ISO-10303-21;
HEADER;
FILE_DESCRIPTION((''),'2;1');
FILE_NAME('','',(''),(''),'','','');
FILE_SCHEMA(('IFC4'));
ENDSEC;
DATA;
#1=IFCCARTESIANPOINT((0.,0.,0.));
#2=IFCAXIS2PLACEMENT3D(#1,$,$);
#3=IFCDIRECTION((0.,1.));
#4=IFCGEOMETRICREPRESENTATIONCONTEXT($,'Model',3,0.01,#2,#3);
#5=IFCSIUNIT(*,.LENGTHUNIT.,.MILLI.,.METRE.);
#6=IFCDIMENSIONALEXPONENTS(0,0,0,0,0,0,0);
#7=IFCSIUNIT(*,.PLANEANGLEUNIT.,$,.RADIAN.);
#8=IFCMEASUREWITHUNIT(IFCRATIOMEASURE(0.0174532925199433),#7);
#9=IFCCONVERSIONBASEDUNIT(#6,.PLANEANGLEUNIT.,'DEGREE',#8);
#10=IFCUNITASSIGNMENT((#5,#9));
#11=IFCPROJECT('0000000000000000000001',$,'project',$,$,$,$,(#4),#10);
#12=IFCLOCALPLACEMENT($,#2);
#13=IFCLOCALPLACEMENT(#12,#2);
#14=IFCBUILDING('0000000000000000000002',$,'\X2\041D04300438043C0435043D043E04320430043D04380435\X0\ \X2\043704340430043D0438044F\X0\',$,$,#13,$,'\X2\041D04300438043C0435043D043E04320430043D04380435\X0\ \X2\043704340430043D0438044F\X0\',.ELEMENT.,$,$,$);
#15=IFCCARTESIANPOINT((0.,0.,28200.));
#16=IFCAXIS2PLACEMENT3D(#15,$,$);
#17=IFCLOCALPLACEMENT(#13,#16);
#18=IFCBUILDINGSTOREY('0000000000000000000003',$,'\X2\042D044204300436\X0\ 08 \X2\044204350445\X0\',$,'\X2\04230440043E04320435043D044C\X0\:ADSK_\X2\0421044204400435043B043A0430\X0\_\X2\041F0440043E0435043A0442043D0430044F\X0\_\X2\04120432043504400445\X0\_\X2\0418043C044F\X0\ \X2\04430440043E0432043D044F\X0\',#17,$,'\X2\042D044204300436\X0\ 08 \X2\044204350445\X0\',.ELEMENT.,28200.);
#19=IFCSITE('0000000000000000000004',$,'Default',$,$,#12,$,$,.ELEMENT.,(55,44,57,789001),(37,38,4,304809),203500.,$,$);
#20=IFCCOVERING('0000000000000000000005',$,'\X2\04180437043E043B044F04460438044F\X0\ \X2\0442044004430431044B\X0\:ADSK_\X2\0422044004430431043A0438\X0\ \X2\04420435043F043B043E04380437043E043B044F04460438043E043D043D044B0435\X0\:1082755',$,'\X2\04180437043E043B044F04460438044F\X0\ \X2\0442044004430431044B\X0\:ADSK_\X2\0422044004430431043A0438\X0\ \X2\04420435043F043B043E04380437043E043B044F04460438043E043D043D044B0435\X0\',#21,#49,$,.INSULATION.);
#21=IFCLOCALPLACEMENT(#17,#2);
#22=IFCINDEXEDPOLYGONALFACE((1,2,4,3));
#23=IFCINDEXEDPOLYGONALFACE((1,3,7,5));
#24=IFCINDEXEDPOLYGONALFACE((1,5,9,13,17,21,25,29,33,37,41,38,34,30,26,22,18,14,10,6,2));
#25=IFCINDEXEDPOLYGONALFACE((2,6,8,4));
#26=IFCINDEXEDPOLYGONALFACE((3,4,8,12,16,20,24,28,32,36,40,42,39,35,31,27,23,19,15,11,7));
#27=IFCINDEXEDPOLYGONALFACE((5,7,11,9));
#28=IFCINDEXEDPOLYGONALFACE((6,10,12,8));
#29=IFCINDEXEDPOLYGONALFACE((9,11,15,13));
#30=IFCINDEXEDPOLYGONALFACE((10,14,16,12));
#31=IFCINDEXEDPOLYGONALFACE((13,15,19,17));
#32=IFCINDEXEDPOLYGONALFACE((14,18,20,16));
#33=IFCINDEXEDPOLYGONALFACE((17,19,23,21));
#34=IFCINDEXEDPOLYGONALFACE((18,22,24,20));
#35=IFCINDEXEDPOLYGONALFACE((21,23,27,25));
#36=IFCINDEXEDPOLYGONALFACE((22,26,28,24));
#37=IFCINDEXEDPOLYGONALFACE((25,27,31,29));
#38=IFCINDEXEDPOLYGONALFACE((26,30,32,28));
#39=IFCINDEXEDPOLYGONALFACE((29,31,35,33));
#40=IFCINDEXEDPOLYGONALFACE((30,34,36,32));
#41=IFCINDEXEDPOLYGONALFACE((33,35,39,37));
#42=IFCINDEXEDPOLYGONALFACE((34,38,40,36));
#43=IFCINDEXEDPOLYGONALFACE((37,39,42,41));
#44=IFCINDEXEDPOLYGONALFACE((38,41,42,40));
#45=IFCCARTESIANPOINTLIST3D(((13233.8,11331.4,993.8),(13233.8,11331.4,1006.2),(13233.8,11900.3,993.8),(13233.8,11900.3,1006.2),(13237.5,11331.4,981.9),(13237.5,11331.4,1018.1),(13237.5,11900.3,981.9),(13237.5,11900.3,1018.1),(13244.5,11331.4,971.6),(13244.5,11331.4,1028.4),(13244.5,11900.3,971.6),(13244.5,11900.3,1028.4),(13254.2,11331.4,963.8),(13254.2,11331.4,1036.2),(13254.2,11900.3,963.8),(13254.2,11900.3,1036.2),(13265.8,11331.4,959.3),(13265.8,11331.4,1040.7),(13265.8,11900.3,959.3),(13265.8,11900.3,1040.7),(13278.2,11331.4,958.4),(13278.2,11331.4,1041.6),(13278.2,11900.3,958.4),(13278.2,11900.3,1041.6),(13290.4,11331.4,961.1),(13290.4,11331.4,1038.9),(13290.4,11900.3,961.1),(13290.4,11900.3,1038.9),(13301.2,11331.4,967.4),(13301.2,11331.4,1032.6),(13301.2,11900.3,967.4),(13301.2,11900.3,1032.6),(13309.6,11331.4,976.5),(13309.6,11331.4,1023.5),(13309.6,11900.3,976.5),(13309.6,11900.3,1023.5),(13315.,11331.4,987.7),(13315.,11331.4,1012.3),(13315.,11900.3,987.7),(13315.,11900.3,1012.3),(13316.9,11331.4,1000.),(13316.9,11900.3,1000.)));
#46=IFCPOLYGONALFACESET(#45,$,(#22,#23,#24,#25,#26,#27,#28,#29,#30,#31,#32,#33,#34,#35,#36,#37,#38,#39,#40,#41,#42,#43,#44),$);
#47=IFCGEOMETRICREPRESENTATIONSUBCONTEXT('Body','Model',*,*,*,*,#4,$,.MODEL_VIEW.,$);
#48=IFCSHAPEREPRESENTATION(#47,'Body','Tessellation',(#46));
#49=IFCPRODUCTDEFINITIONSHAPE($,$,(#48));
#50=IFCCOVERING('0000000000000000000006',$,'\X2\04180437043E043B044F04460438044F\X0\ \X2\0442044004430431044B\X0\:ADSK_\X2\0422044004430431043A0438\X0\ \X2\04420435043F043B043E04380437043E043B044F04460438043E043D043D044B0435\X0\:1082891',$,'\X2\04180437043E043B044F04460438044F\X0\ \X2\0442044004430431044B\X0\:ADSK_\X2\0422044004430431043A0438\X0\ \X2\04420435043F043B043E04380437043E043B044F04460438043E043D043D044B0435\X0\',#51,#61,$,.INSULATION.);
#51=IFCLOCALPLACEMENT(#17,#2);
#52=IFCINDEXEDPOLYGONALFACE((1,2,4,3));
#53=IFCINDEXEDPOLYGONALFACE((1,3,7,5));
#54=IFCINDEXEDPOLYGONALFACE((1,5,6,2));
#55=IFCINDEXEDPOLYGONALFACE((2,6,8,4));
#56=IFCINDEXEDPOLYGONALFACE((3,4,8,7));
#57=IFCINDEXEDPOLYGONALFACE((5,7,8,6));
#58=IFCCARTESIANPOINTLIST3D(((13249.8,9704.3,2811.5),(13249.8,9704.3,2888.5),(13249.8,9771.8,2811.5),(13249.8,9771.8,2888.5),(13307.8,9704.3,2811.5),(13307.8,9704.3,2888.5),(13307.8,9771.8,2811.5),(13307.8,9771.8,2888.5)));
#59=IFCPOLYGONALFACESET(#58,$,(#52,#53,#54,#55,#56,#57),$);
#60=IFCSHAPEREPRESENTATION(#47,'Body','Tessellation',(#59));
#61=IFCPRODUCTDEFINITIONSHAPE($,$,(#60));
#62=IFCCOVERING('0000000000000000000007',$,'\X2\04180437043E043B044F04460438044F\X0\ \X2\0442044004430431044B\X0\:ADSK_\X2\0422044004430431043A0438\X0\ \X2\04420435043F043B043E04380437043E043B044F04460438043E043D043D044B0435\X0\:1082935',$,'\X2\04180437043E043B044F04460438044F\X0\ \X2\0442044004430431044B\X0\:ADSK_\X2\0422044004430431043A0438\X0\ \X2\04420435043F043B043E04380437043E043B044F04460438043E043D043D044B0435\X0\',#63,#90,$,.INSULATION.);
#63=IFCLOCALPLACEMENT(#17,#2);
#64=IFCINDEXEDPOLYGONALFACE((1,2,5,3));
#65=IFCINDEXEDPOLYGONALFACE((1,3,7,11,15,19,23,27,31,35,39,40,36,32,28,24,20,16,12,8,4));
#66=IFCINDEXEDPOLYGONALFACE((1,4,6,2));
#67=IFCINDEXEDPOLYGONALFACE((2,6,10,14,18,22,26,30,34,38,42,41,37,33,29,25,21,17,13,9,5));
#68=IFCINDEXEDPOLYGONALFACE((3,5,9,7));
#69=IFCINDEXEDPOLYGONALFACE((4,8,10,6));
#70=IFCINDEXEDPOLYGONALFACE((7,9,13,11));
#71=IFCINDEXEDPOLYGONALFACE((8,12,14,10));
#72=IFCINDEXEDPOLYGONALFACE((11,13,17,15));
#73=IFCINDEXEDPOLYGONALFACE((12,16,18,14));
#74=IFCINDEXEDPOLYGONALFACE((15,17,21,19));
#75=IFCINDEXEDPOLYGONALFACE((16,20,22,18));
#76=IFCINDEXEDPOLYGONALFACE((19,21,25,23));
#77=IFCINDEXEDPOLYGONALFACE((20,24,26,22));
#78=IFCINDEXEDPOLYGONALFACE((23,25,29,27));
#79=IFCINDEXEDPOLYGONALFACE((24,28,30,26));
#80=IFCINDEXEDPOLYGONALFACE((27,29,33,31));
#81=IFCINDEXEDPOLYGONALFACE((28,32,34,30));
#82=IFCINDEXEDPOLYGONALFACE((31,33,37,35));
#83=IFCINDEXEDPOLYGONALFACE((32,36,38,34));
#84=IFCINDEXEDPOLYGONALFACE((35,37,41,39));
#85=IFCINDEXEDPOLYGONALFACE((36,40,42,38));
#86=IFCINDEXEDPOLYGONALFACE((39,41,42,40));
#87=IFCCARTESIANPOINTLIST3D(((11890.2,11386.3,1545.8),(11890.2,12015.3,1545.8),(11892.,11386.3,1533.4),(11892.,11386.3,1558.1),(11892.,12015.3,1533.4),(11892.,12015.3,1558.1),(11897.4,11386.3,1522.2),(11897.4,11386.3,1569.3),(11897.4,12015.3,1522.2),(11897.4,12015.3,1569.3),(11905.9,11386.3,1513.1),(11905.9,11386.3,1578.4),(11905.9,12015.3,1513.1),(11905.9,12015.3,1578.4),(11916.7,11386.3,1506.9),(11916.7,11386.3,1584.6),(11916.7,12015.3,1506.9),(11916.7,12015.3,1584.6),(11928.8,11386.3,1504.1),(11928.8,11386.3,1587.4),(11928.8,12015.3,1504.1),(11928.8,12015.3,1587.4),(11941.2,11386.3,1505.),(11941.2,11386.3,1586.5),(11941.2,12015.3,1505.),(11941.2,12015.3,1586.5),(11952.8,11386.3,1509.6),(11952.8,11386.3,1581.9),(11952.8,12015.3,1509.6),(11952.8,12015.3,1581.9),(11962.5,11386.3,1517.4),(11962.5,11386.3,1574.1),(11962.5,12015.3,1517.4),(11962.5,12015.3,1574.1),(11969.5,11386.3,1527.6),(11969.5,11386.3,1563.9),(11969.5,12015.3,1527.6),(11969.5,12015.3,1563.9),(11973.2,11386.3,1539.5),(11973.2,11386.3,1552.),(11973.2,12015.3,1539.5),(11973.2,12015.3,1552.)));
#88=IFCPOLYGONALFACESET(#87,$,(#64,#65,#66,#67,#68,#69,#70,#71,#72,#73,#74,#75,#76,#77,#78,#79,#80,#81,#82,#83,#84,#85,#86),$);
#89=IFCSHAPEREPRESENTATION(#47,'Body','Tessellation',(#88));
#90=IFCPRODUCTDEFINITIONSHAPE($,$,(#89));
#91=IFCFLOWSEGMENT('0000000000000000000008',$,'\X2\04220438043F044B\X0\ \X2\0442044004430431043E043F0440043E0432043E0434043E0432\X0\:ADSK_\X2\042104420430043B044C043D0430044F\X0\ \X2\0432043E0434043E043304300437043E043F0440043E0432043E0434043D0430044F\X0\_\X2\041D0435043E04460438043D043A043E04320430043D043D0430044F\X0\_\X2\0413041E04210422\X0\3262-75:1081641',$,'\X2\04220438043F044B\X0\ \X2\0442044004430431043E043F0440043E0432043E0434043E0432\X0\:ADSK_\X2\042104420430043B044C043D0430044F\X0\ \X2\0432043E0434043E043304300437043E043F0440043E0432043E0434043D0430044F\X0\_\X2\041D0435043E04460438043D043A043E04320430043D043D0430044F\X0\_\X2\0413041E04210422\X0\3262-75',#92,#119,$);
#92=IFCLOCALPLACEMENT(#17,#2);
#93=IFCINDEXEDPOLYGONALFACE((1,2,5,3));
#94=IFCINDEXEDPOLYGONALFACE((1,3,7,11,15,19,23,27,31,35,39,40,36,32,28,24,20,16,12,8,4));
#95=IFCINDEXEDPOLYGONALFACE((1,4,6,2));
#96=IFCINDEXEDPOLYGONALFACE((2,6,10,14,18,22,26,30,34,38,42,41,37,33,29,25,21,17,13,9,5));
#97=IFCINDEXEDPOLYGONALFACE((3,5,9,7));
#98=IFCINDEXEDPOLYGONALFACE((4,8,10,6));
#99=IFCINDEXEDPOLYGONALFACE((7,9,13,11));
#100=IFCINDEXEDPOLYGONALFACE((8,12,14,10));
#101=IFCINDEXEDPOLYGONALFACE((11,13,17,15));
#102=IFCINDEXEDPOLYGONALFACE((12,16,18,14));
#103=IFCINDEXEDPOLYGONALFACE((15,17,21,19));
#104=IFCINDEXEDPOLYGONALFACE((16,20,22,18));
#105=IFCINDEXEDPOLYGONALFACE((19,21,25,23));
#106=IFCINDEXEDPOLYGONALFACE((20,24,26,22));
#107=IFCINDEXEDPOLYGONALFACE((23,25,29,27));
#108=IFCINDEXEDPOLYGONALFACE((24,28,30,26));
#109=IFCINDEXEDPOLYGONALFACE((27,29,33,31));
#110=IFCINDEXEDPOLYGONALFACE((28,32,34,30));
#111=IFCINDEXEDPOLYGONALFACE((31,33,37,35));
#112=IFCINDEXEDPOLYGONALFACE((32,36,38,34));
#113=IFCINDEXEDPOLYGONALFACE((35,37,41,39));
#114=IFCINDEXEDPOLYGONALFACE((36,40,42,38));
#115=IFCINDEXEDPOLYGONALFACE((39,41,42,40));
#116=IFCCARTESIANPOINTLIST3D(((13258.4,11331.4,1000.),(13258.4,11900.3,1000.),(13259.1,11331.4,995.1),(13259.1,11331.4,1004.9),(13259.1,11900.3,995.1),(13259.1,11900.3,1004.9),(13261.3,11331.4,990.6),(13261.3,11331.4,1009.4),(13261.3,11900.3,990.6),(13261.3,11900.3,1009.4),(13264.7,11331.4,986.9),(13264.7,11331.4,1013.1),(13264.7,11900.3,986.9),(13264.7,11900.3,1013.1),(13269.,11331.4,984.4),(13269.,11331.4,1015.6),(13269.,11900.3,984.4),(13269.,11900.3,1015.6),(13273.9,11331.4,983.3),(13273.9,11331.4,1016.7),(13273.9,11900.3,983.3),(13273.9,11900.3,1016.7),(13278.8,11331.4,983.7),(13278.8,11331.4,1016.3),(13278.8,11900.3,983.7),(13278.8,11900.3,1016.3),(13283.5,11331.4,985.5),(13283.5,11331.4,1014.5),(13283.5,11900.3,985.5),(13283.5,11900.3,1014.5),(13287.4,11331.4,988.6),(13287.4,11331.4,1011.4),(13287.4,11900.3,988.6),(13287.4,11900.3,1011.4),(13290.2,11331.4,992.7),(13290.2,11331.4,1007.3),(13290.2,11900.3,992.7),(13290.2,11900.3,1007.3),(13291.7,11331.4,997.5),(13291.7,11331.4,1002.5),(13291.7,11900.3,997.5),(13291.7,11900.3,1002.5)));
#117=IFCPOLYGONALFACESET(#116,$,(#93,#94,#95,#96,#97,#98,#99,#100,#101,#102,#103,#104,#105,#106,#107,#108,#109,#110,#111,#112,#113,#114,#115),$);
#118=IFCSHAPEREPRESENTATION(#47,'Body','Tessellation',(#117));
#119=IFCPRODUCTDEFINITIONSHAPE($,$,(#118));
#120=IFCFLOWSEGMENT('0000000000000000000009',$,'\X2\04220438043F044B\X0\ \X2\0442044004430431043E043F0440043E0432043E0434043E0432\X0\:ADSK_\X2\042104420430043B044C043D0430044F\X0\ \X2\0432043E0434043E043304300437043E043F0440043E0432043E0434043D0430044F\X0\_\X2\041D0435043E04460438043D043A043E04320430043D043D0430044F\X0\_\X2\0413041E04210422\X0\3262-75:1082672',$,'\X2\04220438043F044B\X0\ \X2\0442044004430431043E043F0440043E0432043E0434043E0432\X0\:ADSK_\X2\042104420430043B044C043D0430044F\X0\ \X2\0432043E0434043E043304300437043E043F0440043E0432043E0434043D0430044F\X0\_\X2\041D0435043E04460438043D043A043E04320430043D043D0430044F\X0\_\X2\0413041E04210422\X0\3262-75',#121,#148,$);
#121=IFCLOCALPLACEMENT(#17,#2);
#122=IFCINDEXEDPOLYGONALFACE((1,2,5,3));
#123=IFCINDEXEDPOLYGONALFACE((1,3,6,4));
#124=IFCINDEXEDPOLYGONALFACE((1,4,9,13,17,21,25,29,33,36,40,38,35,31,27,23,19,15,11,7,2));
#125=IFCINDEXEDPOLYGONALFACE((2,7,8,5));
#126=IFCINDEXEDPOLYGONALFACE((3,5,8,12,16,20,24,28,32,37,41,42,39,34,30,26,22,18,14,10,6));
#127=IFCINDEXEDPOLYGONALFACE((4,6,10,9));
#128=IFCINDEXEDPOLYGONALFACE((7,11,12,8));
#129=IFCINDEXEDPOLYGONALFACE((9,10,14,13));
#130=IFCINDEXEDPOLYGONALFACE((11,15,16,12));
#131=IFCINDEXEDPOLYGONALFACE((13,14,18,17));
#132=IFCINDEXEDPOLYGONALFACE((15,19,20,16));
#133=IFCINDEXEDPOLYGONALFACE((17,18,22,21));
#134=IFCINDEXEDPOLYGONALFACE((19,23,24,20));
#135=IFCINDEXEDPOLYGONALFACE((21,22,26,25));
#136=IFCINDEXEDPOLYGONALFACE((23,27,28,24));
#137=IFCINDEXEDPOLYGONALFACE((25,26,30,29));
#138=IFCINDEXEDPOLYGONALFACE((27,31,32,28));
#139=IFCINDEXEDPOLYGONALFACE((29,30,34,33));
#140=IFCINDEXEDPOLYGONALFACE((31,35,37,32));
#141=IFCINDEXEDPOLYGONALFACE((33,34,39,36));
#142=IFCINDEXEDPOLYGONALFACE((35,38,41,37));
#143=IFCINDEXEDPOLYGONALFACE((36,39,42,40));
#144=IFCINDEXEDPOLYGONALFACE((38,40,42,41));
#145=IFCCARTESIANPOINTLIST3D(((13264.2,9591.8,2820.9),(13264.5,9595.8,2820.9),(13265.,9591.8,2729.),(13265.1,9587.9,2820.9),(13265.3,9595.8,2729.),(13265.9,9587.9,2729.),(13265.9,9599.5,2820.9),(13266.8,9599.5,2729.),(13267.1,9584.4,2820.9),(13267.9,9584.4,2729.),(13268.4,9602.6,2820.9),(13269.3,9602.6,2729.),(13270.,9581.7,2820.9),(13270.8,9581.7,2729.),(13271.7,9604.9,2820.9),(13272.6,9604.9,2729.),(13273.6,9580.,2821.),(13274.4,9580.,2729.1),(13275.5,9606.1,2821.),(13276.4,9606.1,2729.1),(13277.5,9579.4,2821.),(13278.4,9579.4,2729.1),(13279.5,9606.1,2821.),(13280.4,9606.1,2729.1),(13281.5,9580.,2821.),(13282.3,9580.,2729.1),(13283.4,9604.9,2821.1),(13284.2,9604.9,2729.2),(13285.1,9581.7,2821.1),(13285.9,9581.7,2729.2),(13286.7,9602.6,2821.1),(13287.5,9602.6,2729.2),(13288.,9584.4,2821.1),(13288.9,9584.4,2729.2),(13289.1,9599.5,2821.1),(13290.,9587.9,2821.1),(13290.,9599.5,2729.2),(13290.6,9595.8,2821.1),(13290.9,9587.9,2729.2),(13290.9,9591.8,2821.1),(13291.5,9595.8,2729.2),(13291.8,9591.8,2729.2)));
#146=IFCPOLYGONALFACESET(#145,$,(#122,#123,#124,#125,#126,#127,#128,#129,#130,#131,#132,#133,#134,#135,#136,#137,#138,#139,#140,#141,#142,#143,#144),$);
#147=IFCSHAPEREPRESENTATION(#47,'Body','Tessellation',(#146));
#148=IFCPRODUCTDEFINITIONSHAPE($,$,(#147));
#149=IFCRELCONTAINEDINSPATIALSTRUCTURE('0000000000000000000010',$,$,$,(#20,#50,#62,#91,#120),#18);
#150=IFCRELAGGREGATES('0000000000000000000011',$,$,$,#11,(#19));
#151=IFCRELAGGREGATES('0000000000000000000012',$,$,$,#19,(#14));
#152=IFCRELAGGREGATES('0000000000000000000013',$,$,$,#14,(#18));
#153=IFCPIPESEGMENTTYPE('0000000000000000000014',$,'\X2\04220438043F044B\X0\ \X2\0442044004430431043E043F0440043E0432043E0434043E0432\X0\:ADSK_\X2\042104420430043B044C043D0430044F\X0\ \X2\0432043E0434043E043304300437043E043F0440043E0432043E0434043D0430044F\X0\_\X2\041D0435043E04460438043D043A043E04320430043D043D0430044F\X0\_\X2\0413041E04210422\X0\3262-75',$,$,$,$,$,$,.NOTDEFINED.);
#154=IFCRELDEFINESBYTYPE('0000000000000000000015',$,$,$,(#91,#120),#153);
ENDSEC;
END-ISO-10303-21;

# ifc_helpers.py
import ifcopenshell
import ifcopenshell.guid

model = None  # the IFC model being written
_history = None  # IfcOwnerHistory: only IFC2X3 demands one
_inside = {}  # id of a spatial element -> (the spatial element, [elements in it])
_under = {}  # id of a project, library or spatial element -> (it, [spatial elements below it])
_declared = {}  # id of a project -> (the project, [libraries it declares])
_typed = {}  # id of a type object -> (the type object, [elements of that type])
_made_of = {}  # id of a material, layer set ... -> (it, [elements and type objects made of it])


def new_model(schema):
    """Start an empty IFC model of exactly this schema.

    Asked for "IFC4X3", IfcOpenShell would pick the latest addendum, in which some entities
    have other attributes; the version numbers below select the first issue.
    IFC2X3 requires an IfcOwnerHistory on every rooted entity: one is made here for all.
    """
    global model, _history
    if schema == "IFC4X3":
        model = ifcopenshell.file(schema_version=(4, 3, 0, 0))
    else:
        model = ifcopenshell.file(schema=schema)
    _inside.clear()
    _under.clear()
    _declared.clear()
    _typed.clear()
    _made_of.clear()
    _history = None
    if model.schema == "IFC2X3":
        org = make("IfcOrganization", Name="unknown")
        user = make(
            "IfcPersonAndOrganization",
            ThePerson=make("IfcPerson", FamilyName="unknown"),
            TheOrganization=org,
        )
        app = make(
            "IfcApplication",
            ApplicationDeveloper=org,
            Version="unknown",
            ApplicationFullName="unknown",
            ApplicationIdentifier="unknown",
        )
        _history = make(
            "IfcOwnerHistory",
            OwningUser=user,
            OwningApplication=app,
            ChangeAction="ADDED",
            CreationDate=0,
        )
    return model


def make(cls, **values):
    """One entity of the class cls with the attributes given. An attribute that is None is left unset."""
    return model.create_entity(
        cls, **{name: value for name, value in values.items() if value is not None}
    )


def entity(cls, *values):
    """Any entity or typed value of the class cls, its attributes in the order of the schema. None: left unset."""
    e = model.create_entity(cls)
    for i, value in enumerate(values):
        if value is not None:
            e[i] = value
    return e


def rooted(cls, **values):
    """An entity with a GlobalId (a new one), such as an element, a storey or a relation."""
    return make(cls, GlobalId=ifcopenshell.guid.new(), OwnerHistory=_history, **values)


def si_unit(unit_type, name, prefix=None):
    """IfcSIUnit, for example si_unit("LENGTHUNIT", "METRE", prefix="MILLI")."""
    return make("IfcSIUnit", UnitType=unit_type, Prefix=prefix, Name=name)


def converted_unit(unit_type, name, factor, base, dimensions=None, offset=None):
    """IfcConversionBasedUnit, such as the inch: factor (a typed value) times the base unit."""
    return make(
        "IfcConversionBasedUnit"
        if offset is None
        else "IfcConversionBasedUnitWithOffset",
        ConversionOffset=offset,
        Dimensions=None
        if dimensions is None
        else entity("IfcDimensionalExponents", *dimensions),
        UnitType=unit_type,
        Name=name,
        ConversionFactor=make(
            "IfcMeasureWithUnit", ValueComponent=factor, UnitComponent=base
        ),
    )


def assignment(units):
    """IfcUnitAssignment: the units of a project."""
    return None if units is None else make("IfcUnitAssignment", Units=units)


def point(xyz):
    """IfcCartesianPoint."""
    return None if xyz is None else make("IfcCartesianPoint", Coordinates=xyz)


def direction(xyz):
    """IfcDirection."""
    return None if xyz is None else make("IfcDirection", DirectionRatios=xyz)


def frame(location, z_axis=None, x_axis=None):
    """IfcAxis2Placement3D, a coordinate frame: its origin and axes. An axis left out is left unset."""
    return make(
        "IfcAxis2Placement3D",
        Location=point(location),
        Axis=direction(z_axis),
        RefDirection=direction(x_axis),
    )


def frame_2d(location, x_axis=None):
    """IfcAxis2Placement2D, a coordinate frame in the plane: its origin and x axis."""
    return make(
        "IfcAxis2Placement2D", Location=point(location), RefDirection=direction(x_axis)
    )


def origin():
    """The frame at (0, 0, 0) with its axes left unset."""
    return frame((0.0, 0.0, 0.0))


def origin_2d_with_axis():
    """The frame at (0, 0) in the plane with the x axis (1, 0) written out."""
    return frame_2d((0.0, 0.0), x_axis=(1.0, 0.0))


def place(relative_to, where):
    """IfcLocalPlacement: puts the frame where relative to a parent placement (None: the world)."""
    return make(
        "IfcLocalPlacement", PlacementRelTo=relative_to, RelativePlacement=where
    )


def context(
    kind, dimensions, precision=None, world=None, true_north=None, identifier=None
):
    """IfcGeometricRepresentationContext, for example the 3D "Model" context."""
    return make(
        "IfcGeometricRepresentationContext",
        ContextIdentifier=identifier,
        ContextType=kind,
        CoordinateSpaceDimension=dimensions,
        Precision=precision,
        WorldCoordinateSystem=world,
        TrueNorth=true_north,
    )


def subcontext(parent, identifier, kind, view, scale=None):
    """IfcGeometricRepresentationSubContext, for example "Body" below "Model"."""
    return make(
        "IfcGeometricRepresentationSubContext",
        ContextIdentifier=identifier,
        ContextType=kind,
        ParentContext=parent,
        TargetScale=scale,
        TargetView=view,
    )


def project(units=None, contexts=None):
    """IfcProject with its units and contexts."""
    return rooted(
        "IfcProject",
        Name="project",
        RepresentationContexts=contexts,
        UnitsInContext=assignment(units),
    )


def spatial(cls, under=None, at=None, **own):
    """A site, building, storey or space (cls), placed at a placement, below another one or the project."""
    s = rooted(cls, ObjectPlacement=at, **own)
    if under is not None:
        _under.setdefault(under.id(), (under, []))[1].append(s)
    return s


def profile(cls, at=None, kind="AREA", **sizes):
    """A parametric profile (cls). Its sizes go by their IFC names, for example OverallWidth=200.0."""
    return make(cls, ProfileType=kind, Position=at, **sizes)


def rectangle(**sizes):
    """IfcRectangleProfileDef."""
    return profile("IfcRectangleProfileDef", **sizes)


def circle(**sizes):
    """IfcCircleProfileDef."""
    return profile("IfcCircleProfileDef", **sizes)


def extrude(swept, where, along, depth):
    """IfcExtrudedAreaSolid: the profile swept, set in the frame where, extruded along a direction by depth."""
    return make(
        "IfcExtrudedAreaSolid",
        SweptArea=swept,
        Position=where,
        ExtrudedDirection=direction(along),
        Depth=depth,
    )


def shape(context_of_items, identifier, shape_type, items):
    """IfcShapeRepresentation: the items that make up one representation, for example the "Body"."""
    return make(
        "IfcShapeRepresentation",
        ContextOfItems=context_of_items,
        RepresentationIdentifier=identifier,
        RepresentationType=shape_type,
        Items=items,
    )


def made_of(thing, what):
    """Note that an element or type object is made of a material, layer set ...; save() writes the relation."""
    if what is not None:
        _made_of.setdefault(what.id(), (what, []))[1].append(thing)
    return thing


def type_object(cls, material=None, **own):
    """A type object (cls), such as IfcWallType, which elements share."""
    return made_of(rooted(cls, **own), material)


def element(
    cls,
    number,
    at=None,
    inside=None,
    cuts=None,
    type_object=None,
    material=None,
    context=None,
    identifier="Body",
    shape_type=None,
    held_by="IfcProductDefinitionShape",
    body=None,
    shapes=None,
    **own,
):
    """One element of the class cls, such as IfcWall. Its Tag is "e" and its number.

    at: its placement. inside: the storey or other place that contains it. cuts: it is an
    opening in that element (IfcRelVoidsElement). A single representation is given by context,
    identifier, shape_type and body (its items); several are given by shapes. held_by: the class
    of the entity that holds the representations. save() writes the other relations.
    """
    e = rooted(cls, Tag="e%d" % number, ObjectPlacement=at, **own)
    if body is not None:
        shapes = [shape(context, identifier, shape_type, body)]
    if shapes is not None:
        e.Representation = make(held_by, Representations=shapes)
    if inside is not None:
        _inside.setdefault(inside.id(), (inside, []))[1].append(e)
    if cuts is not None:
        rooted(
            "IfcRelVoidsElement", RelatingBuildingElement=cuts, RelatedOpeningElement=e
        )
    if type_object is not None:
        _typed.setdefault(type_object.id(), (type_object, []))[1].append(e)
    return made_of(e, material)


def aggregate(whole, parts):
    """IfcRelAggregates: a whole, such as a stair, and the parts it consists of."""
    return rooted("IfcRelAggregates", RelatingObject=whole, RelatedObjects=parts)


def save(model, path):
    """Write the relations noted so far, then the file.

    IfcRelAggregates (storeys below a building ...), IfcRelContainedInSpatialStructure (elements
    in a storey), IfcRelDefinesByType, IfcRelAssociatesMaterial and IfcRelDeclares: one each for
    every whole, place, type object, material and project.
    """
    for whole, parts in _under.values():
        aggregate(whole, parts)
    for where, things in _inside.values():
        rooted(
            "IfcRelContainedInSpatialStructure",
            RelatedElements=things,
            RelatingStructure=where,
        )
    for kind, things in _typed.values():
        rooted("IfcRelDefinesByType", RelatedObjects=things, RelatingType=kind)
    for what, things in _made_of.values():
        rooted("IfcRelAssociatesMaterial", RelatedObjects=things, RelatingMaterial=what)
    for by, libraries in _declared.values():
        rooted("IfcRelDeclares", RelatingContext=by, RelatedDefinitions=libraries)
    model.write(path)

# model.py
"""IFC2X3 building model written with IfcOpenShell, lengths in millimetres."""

from ifc_helpers import new_model, entity, si_unit, converted_unit, direction, frame, origin, origin_2d_with_axis, place, context, subcontext, project, spatial, rectangle, circle, extrude, type_object, element, save


model = new_model("IFC2X3")

# Units and contexts
model_context = context("Model", 3, precision=0.01, world=origin(), true_north=direction((0.0, 1.0)))
body_context = subcontext(model_context, "Body", "Model", "MODEL_VIEW")
ifc_project = project(units=[si_unit("LENGTHUNIT", "METRE", prefix="MILLI"), converted_unit("PLANEANGLEUNIT", "DEGREE", entity("IfcRatioMeasure", 0.0174532925199433), si_unit("PLANEANGLEUNIT", "RADIAN"), dimensions=[0, 0, 0, 0, 0, 0, 0])], contexts=[model_context])

# Site, building, storey
site_placement = place(None, origin())
site = spatial("IfcSite", under=ifc_project, at=site_placement, Name="Default", CompositionType="ELEMENT", RefLatitude=(55, 44, 57, 789001), RefLongitude=(37, 38, 4, 304809), RefElevation=203500.0)
building_placement = place(site_placement, origin())
building = spatial("IfcBuilding", under=site, at=building_placement, Name="Наименование здания", LongName="Наименование здания", CompositionType="ELEMENT")
storey_placement = place(building_placement, frame((0.0, 0.0, 28200.0)))
storey = spatial("IfcBuildingStorey", under=building, at=storey_placement, Name="Этаж 08 тех", ObjectType="Уровень:ADSK_Стрелка_Проектная_Вверх_Имя уровня", LongName="Этаж 08 тех", CompositionType="ELEMENT", Elevation=28200.0)

# Coverings
covering_1_placement = place(storey_placement, frame((13231.8, 11331.4, 956.6)))
element("IfcCovering", 1, at=covering_1_placement, inside=storey, Name="Изоляция трубы:ADSK_Трубки теплоизоляционные:1082755", ObjectType="Изоляция трубы:ADSK_Трубки теплоизоляционные", PredefinedType="INSULATION", context=body_context, shape_type="SweptSolid", body=[
    extrude(circle(Radius=41.8, at=origin_2d_with_axis()), frame((43.4, 0.0, 43.4), z_axis=(0.0, 1.0, -0.00001), x_axis=(1.0, 0.0, 0.0)), (0.0, 0.0, 1.0), 568.9),
])
covering_2_placement = place(storey_placement, frame((13249.8, 9704.4, 2811.6)))
element("IfcCovering", 2, at=covering_2_placement, inside=storey, Name="Изоляция трубы:ADSK_Трубки теплоизоляционные:1082891", ObjectType="Изоляция трубы:ADSK_Трубки теплоизоляционные", PredefinedType="INSULATION", context=body_context, shape_type="SweptSolid", body=[
    extrude(rectangle(XDim=76.9, YDim=67.4, at=origin_2d_with_axis()), frame((0.0, 33.7, 38.5), z_axis=(1.0, 0.0, -0.000019), x_axis=(-0.000019, 0.0, -1.0)), (-0.000019, 0.0, 1.0), 58.0),
])
covering_3_placement = place(storey_placement, frame((11888.6, 11386.3, 1502.4)))
element("IfcCovering", 3, at=covering_3_placement, inside=storey, Name="Изоляция трубы:ADSK_Трубки теплоизоляционные:1082935", ObjectType="Изоляция трубы:ADSK_Трубки теплоизоляционные", PredefinedType="INSULATION", context=body_context, shape_type="SweptSolid", body=[
    extrude(circle(Radius=41.8, at=origin_2d_with_axis()), frame((43.4, 0.0, 43.4), z_axis=(0.0, 1.0, 0.000001), x_axis=(-1.0, 0.0, 0.0)), (0.0, 0.0, 1.0), 629.0),
])

# Flow segments
pipe_segment_type = type_object("IfcPipeSegmentType", Name="Типы трубопроводов:ADSK_Стальная водогазопроводная_Неоцинкованная_ГОСТ3262-75", PredefinedType="NOTDEFINED")
flow_segment_1_placement = place(storey_placement, frame((13256.8, 11331.4, 981.6)))
element("IfcFlowSegment", 4, at=flow_segment_1_placement, inside=storey, type_object=pipe_segment_type, Name="Типы трубопроводов:ADSK_Стальная водогазопроводная_Неоцинкованная_ГОСТ3262-75:1081641", ObjectType="Типы трубопроводов:ADSK_Стальная водогазопроводная_Неоцинкованная_ГОСТ3262-75", context=body_context, shape_type="SweptSolid", body=[
    extrude(circle(Radius=16.8, at=origin_2d_with_axis()), frame((18.4, 0.0, 18.4), z_axis=(0.0, 1.0, -0.00001), x_axis=(-1.0, 0.0, 0.0)), (0.0, 0.0, 1.0), 568.9),
])
flow_segment_2_placement = place(storey_placement, frame((13262.5, 9577.8, 2729.0)))
element("IfcFlowSegment", 5, at=flow_segment_2_placement, inside=storey, type_object=pipe_segment_type, Name="Типы трубопроводов:ADSK_Стальная водогазопроводная_Неоцинкованная_ГОСТ3262-75:1082672", ObjectType="Типы трубопроводов:ADSK_Стальная водогазопроводная_Неоцинкованная_ГОСТ3262-75", context=body_context, shape_type="SweptSolid", body=[
    extrude(circle(Radius=13.4, at=origin_2d_with_axis()), frame((15.0, 15.0, 92.0), z_axis=(0.009272, 0.0, -0.999957), x_axis=(0.0, -1.0, 0.0)), (0.0, 0.0, 1.0), 91.9),
])

save(model, "model.ifc")
